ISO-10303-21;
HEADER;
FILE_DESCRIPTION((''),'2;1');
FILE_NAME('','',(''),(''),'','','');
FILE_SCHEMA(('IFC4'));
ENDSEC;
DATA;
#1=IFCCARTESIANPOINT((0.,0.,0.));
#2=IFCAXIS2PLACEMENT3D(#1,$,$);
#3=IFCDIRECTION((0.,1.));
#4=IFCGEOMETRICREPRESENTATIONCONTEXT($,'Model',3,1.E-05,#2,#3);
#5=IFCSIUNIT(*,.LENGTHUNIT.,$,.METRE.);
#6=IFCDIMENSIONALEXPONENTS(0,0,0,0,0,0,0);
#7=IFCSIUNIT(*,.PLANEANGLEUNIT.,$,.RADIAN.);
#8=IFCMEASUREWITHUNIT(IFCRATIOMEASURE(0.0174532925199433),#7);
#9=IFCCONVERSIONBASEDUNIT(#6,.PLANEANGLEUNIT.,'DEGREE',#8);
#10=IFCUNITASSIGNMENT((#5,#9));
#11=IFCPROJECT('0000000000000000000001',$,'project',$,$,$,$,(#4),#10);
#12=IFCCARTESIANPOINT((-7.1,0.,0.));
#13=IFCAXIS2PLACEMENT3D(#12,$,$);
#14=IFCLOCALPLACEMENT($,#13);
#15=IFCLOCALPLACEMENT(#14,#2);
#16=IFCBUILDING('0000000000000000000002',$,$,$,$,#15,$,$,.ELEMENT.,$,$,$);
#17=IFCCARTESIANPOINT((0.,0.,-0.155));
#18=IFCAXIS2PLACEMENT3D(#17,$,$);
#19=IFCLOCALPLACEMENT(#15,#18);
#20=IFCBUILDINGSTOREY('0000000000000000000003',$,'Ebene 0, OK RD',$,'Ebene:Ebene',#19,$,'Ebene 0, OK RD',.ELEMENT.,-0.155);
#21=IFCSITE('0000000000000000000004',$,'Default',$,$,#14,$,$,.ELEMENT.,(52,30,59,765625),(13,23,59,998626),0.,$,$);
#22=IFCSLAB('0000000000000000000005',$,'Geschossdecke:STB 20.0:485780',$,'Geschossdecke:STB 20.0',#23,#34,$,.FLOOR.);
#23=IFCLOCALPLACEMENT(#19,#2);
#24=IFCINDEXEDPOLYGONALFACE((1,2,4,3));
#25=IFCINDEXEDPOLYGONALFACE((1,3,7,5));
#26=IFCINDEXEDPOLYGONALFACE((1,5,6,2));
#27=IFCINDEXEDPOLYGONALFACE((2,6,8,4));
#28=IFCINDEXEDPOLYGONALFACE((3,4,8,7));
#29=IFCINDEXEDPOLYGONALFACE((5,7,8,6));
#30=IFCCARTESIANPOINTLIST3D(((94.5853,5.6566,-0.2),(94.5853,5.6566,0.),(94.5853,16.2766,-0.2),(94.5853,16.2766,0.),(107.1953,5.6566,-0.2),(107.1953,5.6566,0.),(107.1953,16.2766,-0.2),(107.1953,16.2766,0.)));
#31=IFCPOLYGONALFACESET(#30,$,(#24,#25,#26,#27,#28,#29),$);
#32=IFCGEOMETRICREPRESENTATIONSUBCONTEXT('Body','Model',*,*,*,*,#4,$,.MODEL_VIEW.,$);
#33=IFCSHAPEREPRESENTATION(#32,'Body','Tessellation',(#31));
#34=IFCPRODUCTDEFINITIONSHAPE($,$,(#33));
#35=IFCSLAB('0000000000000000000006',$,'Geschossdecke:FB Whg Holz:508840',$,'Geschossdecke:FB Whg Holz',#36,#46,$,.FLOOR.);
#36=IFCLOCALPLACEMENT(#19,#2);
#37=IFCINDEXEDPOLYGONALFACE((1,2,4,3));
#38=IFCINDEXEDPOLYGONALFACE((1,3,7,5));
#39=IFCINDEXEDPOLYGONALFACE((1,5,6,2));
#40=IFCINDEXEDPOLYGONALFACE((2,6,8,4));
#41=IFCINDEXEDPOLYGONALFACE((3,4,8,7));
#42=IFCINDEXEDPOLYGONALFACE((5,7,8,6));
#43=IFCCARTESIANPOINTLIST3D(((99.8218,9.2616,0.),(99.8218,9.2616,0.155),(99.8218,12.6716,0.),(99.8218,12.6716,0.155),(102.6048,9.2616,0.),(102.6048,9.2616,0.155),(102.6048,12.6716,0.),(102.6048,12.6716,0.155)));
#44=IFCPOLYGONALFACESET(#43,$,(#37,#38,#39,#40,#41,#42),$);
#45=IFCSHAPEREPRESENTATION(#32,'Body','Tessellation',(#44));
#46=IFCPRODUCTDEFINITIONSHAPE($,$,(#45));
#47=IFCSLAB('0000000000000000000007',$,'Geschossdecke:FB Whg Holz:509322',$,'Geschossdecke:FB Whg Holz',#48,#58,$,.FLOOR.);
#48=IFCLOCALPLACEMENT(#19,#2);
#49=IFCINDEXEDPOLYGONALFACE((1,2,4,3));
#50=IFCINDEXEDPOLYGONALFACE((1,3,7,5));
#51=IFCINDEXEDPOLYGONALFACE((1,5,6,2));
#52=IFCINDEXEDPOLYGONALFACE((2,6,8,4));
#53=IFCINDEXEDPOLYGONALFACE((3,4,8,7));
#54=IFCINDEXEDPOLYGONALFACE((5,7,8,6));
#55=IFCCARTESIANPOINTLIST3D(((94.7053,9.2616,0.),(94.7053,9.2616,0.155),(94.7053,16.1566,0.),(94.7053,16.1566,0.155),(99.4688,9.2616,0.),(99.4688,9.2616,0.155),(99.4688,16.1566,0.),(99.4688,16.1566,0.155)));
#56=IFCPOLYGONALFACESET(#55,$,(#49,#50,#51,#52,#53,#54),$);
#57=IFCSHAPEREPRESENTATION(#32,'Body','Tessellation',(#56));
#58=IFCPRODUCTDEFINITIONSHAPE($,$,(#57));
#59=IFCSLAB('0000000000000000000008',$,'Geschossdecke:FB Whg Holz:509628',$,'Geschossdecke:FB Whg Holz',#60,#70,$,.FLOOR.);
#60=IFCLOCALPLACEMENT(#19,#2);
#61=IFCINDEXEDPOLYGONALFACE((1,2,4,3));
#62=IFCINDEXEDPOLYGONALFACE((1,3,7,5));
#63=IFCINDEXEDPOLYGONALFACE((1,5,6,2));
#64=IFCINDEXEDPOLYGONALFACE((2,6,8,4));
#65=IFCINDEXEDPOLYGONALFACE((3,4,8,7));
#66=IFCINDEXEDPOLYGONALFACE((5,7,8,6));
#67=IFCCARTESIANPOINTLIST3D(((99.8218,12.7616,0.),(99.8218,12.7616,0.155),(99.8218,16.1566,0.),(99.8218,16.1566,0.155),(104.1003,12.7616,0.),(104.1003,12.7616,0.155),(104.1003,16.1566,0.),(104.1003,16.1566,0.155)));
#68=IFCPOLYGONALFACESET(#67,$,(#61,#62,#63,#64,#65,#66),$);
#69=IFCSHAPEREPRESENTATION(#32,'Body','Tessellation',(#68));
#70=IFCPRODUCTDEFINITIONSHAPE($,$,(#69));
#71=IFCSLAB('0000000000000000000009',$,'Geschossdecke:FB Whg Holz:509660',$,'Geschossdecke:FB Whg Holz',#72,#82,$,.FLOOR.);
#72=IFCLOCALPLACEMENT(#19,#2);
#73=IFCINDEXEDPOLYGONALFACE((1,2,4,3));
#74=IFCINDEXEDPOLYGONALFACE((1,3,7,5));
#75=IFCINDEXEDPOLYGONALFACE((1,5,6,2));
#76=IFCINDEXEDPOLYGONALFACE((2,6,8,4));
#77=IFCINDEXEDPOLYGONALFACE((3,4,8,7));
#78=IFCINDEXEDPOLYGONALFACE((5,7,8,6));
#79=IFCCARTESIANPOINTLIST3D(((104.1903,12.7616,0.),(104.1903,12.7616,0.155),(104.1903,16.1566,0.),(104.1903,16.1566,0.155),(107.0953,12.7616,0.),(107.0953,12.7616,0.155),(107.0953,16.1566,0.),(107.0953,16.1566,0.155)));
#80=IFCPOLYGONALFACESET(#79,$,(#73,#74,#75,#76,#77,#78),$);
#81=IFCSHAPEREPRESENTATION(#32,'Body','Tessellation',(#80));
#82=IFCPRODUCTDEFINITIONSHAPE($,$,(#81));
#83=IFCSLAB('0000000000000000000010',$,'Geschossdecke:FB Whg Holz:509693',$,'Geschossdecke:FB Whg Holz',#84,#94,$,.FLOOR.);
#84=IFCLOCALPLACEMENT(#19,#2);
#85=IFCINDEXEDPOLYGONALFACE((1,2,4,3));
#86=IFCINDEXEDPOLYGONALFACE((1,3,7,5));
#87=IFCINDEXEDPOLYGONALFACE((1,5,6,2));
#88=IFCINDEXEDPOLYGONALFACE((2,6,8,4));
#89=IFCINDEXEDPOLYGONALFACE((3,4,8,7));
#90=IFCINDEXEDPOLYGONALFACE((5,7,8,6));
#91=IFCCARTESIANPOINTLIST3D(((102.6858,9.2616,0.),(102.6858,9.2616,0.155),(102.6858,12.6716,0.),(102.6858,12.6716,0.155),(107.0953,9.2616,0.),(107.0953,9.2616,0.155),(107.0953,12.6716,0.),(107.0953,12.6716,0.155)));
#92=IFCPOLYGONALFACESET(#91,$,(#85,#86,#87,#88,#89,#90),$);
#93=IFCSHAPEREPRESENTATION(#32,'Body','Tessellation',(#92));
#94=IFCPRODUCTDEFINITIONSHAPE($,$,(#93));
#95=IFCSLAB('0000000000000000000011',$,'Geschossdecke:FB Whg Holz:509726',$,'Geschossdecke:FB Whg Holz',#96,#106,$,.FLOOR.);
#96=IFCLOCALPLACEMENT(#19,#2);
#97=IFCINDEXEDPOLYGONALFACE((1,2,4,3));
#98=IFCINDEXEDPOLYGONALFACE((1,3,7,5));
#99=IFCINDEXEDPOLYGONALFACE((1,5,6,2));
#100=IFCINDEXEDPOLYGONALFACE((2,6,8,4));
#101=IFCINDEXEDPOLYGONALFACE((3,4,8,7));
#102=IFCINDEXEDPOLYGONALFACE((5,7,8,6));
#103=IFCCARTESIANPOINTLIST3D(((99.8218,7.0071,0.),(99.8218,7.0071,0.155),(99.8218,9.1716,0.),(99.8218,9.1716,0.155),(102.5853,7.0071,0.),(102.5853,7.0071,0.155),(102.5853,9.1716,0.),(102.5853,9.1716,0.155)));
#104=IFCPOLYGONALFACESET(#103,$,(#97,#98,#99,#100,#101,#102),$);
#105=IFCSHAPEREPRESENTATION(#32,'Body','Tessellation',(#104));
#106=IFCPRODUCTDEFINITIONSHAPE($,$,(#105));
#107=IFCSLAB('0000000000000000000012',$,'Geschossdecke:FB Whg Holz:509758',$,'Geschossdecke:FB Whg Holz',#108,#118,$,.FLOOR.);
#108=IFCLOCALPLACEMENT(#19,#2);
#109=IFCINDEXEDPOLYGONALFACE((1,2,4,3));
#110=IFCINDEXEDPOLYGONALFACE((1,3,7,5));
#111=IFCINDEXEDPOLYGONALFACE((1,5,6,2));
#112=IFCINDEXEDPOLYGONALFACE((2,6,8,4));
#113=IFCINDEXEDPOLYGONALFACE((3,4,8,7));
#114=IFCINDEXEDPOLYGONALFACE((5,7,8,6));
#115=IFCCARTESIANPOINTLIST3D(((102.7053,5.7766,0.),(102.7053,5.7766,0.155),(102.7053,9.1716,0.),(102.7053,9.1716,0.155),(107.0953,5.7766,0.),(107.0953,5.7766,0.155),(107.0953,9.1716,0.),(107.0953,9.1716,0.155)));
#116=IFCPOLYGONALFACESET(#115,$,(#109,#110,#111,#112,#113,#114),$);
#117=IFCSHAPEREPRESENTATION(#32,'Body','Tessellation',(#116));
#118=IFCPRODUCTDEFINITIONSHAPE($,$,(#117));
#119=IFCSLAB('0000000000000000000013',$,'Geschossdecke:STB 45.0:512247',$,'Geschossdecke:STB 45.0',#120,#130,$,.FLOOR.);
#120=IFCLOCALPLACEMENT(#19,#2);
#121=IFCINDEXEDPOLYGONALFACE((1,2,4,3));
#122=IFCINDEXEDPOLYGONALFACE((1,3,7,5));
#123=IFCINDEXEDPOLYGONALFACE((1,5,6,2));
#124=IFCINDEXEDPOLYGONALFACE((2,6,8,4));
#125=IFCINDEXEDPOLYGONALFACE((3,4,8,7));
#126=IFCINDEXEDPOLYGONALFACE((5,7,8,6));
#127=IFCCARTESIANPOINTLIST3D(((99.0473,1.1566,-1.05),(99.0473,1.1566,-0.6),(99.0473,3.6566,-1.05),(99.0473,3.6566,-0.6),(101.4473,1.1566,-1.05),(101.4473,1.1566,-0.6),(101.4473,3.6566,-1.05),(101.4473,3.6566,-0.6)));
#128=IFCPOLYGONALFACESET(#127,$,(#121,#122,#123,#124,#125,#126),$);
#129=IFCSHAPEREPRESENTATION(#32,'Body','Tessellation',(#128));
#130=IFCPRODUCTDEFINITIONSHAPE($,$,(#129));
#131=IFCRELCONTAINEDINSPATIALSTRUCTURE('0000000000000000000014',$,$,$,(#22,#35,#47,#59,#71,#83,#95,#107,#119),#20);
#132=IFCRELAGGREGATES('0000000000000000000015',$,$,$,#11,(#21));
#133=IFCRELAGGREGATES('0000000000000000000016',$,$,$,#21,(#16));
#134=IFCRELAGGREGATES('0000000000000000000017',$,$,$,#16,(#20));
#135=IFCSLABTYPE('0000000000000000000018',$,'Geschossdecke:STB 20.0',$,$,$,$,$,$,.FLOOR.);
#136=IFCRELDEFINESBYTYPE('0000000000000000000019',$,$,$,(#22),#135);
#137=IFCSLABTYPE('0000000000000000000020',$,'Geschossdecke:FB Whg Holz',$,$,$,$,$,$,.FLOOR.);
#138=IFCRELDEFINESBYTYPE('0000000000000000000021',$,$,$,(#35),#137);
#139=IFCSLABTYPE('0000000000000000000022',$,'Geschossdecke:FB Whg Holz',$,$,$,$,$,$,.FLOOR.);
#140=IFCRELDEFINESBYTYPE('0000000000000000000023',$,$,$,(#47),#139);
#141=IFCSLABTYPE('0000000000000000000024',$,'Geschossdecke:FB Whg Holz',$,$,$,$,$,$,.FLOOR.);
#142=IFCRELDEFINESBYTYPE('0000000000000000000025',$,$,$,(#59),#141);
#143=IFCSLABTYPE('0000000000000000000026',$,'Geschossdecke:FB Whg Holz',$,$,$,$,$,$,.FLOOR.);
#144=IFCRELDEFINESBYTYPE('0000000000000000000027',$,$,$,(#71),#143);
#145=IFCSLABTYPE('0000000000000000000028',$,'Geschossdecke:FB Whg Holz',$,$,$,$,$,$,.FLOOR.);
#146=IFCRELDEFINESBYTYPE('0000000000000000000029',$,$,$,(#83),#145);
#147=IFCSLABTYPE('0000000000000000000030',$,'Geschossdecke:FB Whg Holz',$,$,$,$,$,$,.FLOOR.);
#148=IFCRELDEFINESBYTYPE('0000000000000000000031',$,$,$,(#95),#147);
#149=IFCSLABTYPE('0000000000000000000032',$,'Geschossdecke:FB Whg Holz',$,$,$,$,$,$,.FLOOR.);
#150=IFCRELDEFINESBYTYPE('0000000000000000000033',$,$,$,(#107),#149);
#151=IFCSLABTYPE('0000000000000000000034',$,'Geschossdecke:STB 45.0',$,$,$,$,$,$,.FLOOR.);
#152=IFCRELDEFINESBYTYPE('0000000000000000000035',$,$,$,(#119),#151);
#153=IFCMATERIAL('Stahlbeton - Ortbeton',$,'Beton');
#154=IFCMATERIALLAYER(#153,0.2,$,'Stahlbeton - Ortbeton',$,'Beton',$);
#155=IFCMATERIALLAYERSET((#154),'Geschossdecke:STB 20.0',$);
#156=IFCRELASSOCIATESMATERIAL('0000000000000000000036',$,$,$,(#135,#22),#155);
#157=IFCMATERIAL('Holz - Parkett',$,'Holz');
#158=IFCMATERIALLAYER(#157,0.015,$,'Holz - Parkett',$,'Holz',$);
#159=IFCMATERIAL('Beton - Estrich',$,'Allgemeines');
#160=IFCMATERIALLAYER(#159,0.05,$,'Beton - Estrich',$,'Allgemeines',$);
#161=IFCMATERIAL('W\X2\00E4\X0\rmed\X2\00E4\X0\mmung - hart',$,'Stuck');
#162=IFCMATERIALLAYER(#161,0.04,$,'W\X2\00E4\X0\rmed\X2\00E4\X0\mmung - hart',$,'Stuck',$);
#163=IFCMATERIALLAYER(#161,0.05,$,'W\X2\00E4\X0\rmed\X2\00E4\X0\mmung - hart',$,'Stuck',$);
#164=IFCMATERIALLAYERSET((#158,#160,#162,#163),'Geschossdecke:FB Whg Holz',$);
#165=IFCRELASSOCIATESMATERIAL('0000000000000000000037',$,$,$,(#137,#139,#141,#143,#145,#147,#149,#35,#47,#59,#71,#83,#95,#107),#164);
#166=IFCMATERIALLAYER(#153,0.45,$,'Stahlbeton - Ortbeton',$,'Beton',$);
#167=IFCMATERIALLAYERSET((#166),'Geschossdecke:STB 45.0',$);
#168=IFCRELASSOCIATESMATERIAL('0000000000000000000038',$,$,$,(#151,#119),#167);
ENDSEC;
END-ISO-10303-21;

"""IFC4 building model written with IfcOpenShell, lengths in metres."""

from ifc_helpers import new_model, entity, si_unit, converted_unit, direction, frame, frame_2d, origin, origin_2d_with_axis, place, context, subcontext, project, spatial, rectangle, extrude, material, layer, layer_set, layer_usage, type_object, element, save


model = new_model("IFC4")

# Units and contexts
model_context = context("Model", 3, precision=1e-05, world=origin(), true_north=direction((0.0, 1.0)))
body_context = subcontext(model_context, "Body", "Model", "MODEL_VIEW")
ifc_project = project(units=[si_unit("LENGTHUNIT", "METRE"), converted_unit("PLANEANGLEUNIT", "DEGREE", entity("IfcRatioMeasure", 0.0174532925199433), si_unit("PLANEANGLEUNIT", "RADIAN"), dimensions=[0, 0, 0, 0, 0, 0, 0])], contexts=[model_context])

# Site, building, storey
site_placement = place(None, frame((-7.1, 0.0, 0.0)))
site = spatial("IfcSite", under=ifc_project, at=site_placement, Name="Default", CompositionType="ELEMENT", RefLatitude=(52, 30, 59, 765625), RefLongitude=(13, 23, 59, 998626), RefElevation=0.0)
building_placement = place(site_placement, origin())
building = spatial("IfcBuilding", under=site, at=building_placement, CompositionType="ELEMENT")
storey_placement = place(building_placement, frame((0.0, 0.0, -0.155)))
storey = spatial("IfcBuildingStorey", under=building, at=storey_placement, Name="Ebene 0, OK RD", ObjectType="Ebene:Ebene", LongName="Ebene 0, OK RD", CompositionType="ELEMENT", Elevation=-0.155)

# Slabs
ifc_material_1 = material(Name="Stahlbeton - Ortbeton", Category="Beton")
ifc_layer_1 = layer(ifc_material_1, 0.2, Name="Stahlbeton - Ortbeton", Category="Beton")
ifc_layer_set_1 = layer_set([ifc_layer_1], Name="Geschossdecke:STB 20.0")
ifc_layer_usage_1 = layer_usage(ifc_layer_set_1, "AXIS3", "POSITIVE", 0.0)
slab_type_1 = type_object("IfcSlabType", Name="Geschossdecke:STB 20.0", PredefinedType="FLOOR", material=ifc_layer_set_1)
slab_1_placement = place(storey_placement, origin())
element("IfcSlab", 1, at=slab_1_placement, inside=storey, type_object=slab_type_1, material=ifc_layer_usage_1, Name="Geschossdecke:STB 20.0:485780", ObjectType="Geschossdecke:STB 20.0", PredefinedType="FLOOR", context=body_context, shape_type="SweptSolid", body=[
    extrude(rectangle(XDim=10.62, YDim=12.61, at=frame_2d((0.0, 0.0), x_axis=(1.0, 0.0))), frame((100.8903, 10.9666, 0.0), z_axis=(0.0, 0.0, -1.0), x_axis=(0.0, 1.0, 0.0)), (0.0, 0.0, 1.0), 0.2),
])
ifc_material_2 = material(Name="Holz - Parkett", Category="Holz")
ifc_layer_2 = layer(ifc_material_2, 0.015, Name="Holz - Parkett", Category="Holz")
ifc_material_3 = material(Name="Beton - Estrich", Category="Allgemeines")
ifc_layer_3 = layer(ifc_material_3, 0.05, Name="Beton - Estrich", Category="Allgemeines")
ifc_material_4 = material(Name="Wärmedämmung - hart", Category="Stuck")
ifc_layer_4 = layer(ifc_material_4, 0.04, Name="Wärmedämmung - hart", Category="Stuck")
ifc_layer_5 = layer(ifc_material_4, 0.05, Name="Wärmedämmung - hart", Category="Stuck")
ifc_layer_set_2 = layer_set([ifc_layer_2, ifc_layer_3, ifc_layer_4, ifc_layer_5], Name="Geschossdecke:FB Whg Holz")
ifc_layer_usage_2 = layer_usage(ifc_layer_set_2, "AXIS3", "POSITIVE", 0.0)
slab_type_2 = type_object("IfcSlabType", Name="Geschossdecke:FB Whg Holz", PredefinedType="FLOOR", material=ifc_layer_set_2)
slab_2_placement = place(storey_placement, origin())
element("IfcSlab", 2, at=slab_2_placement, inside=storey, type_object=slab_type_2, material=ifc_layer_usage_2, Name="Geschossdecke:FB Whg Holz:508840", ObjectType="Geschossdecke:FB Whg Holz", PredefinedType="FLOOR", context=body_context, shape_type="SweptSolid", body=[
    extrude(rectangle(XDim=3.41, YDim=2.783, at=frame_2d((0.0, 0.0), x_axis=(1.0, 0.0))), frame((101.2133, 10.9666, 0.155), z_axis=(0.0, 0.0, -1.0), x_axis=(0.0, 1.0, 0.0)), (0.0, 0.0, 1.0), 0.155),
])
ifc_layer_usage_3 = layer_usage(ifc_layer_set_2, "AXIS3", "POSITIVE", 0.0)
slab_type_3 = type_object("IfcSlabType", Name="Geschossdecke:FB Whg Holz", PredefinedType="FLOOR", material=ifc_layer_set_2)
slab_3_placement = place(storey_placement, origin())
element("IfcSlab", 3, at=slab_3_placement, inside=storey, type_object=slab_type_3, material=ifc_layer_usage_3, Name="Geschossdecke:FB Whg Holz:509322", ObjectType="Geschossdecke:FB Whg Holz", PredefinedType="FLOOR", context=body_context, shape_type="SweptSolid", body=[
    extrude(rectangle(XDim=6.895, YDim=4.7635, at=frame_2d((0.0, 0.0), x_axis=(1.0, 0.0))), frame((97.0871, 12.7091, 0.155), z_axis=(0.0, 0.0, -1.0), x_axis=(0.0, 1.0, 0.0)), (0.0, 0.0, 1.0), 0.155),
])
ifc_layer_usage_4 = layer_usage(ifc_layer_set_2, "AXIS3", "POSITIVE", 0.0)
slab_type_4 = type_object("IfcSlabType", Name="Geschossdecke:FB Whg Holz", PredefinedType="FLOOR", material=ifc_layer_set_2)
slab_4_placement = place(storey_placement, origin())
element("IfcSlab", 4, at=slab_4_placement, inside=storey, type_object=slab_type_4, material=ifc_layer_usage_4, Name="Geschossdecke:FB Whg Holz:509628", ObjectType="Geschossdecke:FB Whg Holz", PredefinedType="FLOOR", context=body_context, shape_type="SweptSolid", body=[
    extrude(rectangle(XDim=3.395, YDim=4.2785, at=frame_2d((0.0, 0.0), x_axis=(1.0, 0.0))), frame((101.9611, 14.4591, 0.155), z_axis=(0.0, 0.0, -1.0), x_axis=(0.0, 1.0, 0.0)), (0.0, 0.0, 1.0), 0.155),
])
ifc_layer_usage_5 = layer_usage(ifc_layer_set_2, "AXIS3", "POSITIVE", 0.0)
slab_type_5 = type_object("IfcSlabType", Name="Geschossdecke:FB Whg Holz", PredefinedType="FLOOR", material=ifc_layer_set_2)
slab_5_placement = place(storey_placement, origin())
element("IfcSlab", 5, at=slab_5_placement, inside=storey, type_object=slab_type_5, material=ifc_layer_usage_5, Name="Geschossdecke:FB Whg Holz:509660", ObjectType="Geschossdecke:FB Whg Holz", PredefinedType="FLOOR", context=body_context, shape_type="SweptSolid", body=[
    extrude(rectangle(XDim=3.395, YDim=2.905, at=frame_2d((0.0, 0.0), x_axis=(1.0, 0.0))), frame((105.6428, 14.4591, 0.155), z_axis=(0.0, 0.0, -1.0), x_axis=(0.0, 1.0, 0.0)), (0.0, 0.0, 1.0), 0.155),
])
ifc_layer_usage_6 = layer_usage(ifc_layer_set_2, "AXIS3", "POSITIVE", 0.0)
slab_type_6 = type_object("IfcSlabType", Name="Geschossdecke:FB Whg Holz", PredefinedType="FLOOR", material=ifc_layer_set_2)
slab_6_placement = place(storey_placement, origin())
element("IfcSlab", 6, at=slab_6_placement, inside=storey, type_object=slab_type_6, material=ifc_layer_usage_6, Name="Geschossdecke:FB Whg Holz:509693", ObjectType="Geschossdecke:FB Whg Holz", PredefinedType="FLOOR", context=body_context, shape_type="SweptSolid", body=[
    extrude(rectangle(XDim=3.41, YDim=4.4095, at=frame_2d((0.0, 0.0), x_axis=(1.0, 0.0))), frame((104.8906, 10.9666, 0.155), z_axis=(0.0, 0.0, -1.0), x_axis=(0.0, 1.0, 0.0)), (0.0, 0.0, 1.0), 0.155),
])
ifc_layer_usage_7 = layer_usage(ifc_layer_set_2, "AXIS3", "POSITIVE", 0.0)
slab_type_7 = type_object("IfcSlabType", Name="Geschossdecke:FB Whg Holz", PredefinedType="FLOOR", material=ifc_layer_set_2)
slab_7_placement = place(storey_placement, origin())
element("IfcSlab", 7, at=slab_7_placement, inside=storey, type_object=slab_type_7, material=ifc_layer_usage_7, Name="Geschossdecke:FB Whg Holz:509726", ObjectType="Geschossdecke:FB Whg Holz", PredefinedType="FLOOR", context=body_context, shape_type="SweptSolid", body=[
    extrude(rectangle(XDim=2.1645, YDim=2.7635, at=frame_2d((0.0, 0.0), x_axis=(1.0, 0.0))), frame((101.2036, 8.0894, 0.155), z_axis=(0.0, 0.0, -1.0), x_axis=(0.0, 1.0, 0.0)), (0.0, 0.0, 1.0), 0.155),
])
ifc_layer_usage_8 = layer_usage(ifc_layer_set_2, "AXIS3", "POSITIVE", 0.0)
slab_type_8 = type_object("IfcSlabType", Name="Geschossdecke:FB Whg Holz", PredefinedType="FLOOR", material=ifc_layer_set_2)
slab_8_placement = place(storey_placement, origin())
element("IfcSlab", 8, at=slab_8_placement, inside=storey, type_object=slab_type_8, material=ifc_layer_usage_8, Name="Geschossdecke:FB Whg Holz:509758", ObjectType="Geschossdecke:FB Whg Holz", PredefinedType="FLOOR", context=body_context, shape_type="SweptSolid", body=[
    extrude(rectangle(XDim=3.395, YDim=4.39, at=frame_2d((0.0, 0.0), x_axis=(1.0, 0.0))), frame((104.9003, 7.4741, 0.155), z_axis=(0.0, 0.0, -1.0), x_axis=(0.0, 1.0, 0.0)), (0.0, 0.0, 1.0), 0.155),
])
ifc_layer_6 = layer(ifc_material_1, 0.45, Name="Stahlbeton - Ortbeton", Category="Beton")
ifc_layer_set_3 = layer_set([ifc_layer_6], Name="Geschossdecke:STB 45.0")
ifc_layer_usage_9 = layer_usage(ifc_layer_set_3, "AXIS3", "POSITIVE", 0.0)
slab_type_9 = type_object("IfcSlabType", Name="Geschossdecke:STB 45.0", PredefinedType="FLOOR", material=ifc_layer_set_3)
slab_9_placement = place(storey_placement, origin())
element("IfcSlab", 9, at=slab_9_placement, inside=storey, type_object=slab_type_9, material=ifc_layer_usage_9, Name="Geschossdecke:STB 45.0:512247", ObjectType="Geschossdecke:STB 45.0", PredefinedType="FLOOR", context=body_context, shape_type="SweptSolid", body=[
    extrude(rectangle(XDim=2.5, YDim=2.4, at=origin_2d_with_axis()), frame((100.2473, 2.4066, -0.6), z_axis=(0.0, 0.0, -1.0), x_axis=(0.0, 1.0, 0.0)), (0.0, 0.0, 1.0), 0.45),
])

save(model, "model.ifc")
